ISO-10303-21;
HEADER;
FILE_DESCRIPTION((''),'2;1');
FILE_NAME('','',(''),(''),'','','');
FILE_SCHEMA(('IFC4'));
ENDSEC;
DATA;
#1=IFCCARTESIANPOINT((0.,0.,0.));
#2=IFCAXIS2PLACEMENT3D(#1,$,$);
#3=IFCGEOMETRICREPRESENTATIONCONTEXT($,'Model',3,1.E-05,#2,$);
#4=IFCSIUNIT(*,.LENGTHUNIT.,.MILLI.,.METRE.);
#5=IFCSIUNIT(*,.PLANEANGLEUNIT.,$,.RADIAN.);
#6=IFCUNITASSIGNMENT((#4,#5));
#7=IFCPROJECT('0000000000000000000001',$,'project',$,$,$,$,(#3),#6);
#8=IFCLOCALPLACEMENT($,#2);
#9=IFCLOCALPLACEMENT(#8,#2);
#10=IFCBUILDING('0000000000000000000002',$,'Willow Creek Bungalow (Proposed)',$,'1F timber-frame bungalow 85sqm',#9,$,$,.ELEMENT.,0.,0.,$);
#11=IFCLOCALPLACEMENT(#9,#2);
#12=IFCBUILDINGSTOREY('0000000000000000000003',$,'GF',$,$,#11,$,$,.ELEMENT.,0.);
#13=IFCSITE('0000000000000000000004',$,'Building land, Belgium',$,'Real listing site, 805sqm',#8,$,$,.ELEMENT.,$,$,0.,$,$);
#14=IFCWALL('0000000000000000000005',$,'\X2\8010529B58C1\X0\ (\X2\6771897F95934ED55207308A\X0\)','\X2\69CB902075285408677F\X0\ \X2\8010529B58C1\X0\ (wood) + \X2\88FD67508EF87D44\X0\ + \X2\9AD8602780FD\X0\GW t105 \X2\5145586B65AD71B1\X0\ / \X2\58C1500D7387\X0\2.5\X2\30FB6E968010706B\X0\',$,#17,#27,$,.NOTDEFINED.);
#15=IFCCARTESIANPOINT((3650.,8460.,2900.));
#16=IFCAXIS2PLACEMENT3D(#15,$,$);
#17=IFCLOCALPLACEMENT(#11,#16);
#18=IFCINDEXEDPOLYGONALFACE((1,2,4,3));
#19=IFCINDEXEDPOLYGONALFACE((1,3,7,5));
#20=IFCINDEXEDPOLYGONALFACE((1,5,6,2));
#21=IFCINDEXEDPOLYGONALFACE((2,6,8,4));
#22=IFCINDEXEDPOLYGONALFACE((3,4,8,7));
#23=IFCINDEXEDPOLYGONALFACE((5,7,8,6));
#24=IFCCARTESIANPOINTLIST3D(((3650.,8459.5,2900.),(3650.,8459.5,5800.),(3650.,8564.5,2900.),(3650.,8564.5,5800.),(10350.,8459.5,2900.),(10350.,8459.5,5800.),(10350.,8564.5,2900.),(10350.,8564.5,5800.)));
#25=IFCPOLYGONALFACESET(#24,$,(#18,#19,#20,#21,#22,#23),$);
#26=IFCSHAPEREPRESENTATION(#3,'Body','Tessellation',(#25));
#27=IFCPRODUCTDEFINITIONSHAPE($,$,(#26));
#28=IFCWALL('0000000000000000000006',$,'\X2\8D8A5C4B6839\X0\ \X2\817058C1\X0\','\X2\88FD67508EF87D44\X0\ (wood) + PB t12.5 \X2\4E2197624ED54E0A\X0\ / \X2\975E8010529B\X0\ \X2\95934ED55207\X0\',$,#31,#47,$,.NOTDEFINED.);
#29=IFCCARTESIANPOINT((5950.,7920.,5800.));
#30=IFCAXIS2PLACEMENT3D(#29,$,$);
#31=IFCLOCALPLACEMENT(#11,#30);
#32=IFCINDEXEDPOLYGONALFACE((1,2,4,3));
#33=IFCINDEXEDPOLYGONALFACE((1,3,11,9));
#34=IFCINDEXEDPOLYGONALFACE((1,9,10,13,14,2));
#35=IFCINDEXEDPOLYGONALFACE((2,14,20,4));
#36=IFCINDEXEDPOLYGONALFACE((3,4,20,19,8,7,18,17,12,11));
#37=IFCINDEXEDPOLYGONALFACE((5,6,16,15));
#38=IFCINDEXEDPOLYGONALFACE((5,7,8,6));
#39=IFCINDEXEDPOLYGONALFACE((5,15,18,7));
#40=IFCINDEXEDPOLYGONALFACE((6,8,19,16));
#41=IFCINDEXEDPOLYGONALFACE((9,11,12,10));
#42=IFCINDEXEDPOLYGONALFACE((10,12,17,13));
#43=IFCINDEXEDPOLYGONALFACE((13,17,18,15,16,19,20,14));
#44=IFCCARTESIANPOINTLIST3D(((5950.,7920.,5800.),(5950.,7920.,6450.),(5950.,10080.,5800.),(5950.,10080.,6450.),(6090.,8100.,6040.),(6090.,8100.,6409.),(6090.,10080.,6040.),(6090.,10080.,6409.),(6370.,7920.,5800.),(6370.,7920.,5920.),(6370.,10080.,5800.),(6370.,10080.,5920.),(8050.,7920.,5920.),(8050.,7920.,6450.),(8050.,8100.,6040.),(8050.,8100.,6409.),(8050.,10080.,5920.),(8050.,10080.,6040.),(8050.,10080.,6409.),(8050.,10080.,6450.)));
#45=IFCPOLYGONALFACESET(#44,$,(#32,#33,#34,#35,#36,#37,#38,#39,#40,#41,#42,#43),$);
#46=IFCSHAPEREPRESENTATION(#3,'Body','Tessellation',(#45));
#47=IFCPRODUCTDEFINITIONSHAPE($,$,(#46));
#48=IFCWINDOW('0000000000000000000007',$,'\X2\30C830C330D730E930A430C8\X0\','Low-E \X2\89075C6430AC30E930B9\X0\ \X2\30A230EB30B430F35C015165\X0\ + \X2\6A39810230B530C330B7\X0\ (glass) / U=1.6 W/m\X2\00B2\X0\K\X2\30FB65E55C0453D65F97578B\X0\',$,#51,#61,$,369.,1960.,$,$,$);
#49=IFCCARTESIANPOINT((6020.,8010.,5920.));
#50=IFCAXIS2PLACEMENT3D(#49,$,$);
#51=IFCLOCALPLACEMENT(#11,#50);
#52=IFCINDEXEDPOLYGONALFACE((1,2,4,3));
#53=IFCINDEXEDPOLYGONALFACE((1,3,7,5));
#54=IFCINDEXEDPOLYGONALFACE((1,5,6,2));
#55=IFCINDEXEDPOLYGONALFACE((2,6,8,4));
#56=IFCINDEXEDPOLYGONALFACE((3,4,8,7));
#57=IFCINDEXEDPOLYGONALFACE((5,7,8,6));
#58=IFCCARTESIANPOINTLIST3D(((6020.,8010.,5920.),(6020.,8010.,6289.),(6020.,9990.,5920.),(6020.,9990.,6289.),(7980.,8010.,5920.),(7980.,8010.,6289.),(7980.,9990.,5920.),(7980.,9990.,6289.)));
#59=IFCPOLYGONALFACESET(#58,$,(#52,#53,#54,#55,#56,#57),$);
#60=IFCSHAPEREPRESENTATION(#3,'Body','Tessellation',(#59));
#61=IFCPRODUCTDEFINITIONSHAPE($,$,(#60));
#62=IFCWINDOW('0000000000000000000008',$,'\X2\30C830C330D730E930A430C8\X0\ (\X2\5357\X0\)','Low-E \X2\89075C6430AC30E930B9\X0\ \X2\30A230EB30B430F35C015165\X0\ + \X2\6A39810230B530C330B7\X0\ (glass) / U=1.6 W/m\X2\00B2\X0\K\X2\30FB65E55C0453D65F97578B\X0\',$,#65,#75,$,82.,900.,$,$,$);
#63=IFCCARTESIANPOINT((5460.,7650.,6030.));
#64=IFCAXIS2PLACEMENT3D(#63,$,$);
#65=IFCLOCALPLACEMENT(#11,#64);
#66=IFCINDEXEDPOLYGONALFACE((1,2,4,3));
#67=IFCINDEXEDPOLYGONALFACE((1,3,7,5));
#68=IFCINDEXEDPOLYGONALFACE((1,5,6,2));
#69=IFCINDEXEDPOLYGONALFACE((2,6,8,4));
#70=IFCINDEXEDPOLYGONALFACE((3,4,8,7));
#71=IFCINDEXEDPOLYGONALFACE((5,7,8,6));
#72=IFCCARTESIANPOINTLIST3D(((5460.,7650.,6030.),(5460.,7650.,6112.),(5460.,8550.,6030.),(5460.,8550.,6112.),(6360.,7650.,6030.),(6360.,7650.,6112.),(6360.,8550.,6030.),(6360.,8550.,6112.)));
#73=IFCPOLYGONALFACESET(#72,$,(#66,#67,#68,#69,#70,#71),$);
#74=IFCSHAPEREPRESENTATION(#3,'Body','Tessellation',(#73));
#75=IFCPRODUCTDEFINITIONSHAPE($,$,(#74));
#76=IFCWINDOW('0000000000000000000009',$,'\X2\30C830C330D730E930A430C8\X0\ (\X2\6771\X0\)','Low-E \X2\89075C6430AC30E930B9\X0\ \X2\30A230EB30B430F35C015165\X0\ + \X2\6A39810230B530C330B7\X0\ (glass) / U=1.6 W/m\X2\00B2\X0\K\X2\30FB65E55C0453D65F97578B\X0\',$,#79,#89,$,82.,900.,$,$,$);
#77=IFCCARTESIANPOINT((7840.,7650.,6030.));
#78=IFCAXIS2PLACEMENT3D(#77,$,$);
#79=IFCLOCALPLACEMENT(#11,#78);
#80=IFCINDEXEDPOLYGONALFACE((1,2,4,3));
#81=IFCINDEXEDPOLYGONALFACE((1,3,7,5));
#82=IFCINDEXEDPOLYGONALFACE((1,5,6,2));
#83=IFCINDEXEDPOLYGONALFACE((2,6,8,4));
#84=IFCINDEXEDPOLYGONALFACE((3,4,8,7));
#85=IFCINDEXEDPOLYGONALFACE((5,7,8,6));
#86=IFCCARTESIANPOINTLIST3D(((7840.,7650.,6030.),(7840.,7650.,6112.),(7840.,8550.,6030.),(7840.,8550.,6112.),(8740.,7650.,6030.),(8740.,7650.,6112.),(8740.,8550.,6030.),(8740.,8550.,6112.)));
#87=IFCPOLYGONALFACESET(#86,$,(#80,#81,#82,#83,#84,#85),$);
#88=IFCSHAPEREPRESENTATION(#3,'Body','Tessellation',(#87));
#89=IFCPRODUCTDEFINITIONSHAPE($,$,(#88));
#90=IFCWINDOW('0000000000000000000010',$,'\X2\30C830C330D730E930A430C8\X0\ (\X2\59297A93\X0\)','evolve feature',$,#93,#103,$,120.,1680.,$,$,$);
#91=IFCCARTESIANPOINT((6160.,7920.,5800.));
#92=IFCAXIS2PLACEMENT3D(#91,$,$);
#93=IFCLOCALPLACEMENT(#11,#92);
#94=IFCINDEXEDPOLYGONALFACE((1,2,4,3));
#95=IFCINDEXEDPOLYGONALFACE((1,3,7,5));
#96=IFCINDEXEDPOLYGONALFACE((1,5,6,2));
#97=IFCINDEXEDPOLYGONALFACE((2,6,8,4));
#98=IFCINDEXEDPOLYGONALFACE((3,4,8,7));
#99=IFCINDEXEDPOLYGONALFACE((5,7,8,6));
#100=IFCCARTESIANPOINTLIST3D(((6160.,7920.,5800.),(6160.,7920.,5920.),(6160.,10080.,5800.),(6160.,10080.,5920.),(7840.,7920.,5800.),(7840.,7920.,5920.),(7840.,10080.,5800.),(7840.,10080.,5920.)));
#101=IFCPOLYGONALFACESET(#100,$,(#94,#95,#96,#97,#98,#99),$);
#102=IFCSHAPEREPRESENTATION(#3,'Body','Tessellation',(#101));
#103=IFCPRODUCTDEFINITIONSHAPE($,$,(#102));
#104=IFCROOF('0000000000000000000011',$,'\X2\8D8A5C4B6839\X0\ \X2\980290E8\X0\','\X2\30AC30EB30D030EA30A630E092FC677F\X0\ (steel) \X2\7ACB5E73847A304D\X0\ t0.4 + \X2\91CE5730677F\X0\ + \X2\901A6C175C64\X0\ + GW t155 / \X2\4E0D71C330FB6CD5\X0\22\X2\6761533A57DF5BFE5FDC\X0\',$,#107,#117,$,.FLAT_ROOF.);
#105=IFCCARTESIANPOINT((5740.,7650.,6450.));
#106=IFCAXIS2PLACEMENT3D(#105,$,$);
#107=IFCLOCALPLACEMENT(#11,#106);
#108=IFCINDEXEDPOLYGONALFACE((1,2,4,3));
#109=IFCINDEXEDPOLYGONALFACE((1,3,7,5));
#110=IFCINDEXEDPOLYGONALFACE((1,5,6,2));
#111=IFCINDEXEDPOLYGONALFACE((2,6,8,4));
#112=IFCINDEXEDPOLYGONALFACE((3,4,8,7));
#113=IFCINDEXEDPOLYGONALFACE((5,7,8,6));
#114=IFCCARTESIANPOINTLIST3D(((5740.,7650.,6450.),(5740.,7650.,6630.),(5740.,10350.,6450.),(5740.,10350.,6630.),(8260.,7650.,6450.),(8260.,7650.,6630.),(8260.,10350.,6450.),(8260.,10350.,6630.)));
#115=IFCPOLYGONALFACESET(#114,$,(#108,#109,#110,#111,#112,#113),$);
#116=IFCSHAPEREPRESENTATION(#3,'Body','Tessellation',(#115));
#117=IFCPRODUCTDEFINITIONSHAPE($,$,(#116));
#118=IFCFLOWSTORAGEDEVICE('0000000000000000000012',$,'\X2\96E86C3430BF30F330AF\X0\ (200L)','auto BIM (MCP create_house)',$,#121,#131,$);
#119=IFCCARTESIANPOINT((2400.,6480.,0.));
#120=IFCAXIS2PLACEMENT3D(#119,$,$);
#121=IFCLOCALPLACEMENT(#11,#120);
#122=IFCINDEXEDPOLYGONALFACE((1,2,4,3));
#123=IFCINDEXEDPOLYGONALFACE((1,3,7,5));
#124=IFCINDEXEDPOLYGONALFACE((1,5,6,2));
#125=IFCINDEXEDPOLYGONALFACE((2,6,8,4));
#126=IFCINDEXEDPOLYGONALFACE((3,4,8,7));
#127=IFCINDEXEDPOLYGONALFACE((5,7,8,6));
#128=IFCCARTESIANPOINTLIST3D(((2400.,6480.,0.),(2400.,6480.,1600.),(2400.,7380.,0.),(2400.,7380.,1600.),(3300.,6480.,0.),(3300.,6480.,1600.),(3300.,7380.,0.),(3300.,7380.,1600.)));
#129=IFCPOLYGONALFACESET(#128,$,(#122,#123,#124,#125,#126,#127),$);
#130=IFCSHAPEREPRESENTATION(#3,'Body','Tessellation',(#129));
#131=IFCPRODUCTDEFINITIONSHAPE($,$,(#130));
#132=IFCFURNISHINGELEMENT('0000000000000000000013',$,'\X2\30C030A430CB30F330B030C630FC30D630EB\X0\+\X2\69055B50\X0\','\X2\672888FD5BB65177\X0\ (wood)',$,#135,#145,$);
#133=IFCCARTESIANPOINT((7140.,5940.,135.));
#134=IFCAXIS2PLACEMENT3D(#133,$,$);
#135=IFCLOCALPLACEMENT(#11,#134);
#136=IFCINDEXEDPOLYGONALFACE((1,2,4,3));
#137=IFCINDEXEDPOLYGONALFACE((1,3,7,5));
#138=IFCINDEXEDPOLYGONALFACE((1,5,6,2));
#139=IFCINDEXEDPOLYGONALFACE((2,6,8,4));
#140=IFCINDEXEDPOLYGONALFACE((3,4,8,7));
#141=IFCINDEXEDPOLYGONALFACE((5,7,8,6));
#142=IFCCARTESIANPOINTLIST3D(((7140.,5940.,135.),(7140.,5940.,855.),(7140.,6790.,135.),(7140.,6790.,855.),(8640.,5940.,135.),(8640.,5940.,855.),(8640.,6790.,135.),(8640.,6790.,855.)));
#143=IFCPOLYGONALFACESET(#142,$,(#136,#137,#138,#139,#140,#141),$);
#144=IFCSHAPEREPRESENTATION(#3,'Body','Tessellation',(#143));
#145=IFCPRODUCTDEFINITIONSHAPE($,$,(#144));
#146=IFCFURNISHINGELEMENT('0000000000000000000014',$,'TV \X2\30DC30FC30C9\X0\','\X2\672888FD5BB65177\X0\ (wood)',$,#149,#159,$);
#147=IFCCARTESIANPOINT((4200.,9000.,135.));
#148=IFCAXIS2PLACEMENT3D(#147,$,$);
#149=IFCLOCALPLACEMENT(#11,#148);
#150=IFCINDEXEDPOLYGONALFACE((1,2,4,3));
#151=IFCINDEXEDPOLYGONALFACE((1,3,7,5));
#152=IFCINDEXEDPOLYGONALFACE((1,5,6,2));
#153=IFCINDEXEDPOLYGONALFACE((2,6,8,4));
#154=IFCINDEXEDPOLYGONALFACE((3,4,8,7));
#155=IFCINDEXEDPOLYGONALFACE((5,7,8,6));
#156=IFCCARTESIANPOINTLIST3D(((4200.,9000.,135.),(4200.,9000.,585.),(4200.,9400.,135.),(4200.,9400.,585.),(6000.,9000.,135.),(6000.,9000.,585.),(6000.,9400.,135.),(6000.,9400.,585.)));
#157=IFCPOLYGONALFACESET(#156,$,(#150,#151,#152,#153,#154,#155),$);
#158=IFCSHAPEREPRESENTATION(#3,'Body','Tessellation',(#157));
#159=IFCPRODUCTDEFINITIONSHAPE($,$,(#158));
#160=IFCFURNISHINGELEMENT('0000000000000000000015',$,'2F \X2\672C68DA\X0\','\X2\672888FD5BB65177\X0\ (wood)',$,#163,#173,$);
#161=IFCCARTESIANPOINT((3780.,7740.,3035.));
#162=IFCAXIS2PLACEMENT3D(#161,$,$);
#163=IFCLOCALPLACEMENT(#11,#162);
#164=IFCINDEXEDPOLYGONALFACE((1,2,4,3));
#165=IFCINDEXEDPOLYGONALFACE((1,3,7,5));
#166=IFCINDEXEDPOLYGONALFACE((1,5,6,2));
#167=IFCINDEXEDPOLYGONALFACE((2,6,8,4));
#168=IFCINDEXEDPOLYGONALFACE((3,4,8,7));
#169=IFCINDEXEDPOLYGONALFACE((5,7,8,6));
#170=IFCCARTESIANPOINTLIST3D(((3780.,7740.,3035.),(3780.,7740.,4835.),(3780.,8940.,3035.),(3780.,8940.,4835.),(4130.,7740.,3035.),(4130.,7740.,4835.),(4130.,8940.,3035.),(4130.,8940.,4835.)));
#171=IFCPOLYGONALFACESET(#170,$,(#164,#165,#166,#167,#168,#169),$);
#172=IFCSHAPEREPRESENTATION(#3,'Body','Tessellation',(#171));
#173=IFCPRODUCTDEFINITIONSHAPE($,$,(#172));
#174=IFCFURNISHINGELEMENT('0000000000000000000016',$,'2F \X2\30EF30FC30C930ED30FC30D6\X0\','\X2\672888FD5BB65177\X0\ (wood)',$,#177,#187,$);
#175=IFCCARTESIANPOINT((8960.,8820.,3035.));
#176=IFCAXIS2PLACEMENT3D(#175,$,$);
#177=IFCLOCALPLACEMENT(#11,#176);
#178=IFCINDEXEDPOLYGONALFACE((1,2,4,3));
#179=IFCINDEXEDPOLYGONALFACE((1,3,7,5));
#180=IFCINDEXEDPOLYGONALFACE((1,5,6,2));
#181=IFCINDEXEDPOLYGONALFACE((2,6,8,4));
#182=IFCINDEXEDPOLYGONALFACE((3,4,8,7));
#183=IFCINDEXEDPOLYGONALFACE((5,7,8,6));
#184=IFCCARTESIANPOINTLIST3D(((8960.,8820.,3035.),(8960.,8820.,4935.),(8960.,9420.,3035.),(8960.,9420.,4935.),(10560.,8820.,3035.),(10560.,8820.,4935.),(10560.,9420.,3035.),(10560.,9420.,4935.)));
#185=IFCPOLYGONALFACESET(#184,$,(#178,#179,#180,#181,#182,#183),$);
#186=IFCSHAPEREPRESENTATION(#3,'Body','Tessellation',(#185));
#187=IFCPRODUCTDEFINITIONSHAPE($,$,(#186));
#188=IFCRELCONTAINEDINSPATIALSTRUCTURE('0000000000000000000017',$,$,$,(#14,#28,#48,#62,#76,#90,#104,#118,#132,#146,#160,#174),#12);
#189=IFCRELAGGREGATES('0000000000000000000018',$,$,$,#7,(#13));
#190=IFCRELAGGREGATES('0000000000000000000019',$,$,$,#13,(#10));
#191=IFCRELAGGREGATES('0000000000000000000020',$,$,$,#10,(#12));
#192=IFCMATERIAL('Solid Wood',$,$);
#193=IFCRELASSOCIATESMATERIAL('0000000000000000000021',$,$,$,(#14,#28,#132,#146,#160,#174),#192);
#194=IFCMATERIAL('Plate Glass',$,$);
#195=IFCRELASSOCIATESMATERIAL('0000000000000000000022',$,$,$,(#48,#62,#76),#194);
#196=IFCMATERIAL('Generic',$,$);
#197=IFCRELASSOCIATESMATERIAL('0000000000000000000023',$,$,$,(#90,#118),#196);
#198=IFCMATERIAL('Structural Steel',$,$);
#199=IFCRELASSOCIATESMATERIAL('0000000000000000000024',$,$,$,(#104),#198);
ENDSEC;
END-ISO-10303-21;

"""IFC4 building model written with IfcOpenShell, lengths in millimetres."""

from ifc_helpers import new_model, si_unit, frame, frame_2d, origin, place, context, project, spatial, rectangle, extrude, material, element, fill, save


model = new_model("IFC4")

# Units and contexts
model_context = context("Model", 3, precision=1e-05, world=origin())
ifc_project = project(units=[si_unit("LENGTHUNIT", "METRE", prefix="MILLI"), si_unit("PLANEANGLEUNIT", "RADIAN")], contexts=[model_context])

# Site, building, storey
site_placement = place(None, origin())
site = spatial("IfcSite", under=ifc_project, at=site_placement, Name="Building land, Belgium", ObjectType="Real listing site, 805sqm", CompositionType="ELEMENT", RefElevation=0.0)
building_placement = place(site_placement, origin())
building = spatial("IfcBuilding", under=site, at=building_placement, Name="Willow Creek Bungalow (Proposed)", ObjectType="1F timber-frame bungalow 85sqm", CompositionType="ELEMENT", ElevationOfRefHeight=0.0, ElevationOfTerrain=0.0)
storey_placement = place(building_placement, origin())
storey = spatial("IfcBuildingStorey", under=building, at=storey_placement, Name="GF", CompositionType="ELEMENT", Elevation=0.0)

# Wall
ifc_material_1 = material(Name="Solid Wood")
wall_1_placement = place(storey_placement, frame((3650.0, 8460.0, 2900.0)))
element("IfcWall", 1, at=wall_1_placement, inside=storey, material=ifc_material_1, Name="耐力壁 (東西間仕切り)", Description="構造用合板 耐力壁 (wood) + 製材軸組 + 高性能GW t105 充填断熱 / 壁倍率2.5・準耐火", PredefinedType="NOTDEFINED", context=model_context, shape_type="SweptSolid", body=[
    extrude(rectangle(XDim=6700.0, YDim=105.0, at=frame_2d((3350.0, 52.0))), frame((3650.0, 8460.0, 2900.0)), (0.0, 0.0, 1.0), 2900.0),
])

# Wall, openings, windows
wall_2_placement = place(storey_placement, frame((5950.0, 7920.0, 5800.0)))
wall_2 = element("IfcWall", 2, at=wall_2_placement, inside=storey, material=ifc_material_1, Name="越屋根 腰壁", Description="製材軸組 (wood) + PB t12.5 両面仕上 / 非耐力 間仕切", PredefinedType="NOTDEFINED", context=model_context, shape_type="SweptSolid", body=[
    extrude(rectangle(XDim=2100.0, YDim=2160.0, at=frame_2d((1050.0, 1080.0))), frame((5950.0, 7920.0, 5800.0)), (0.0, 0.0, 1.0), 650.0),
])
opening_1_placement = place(storey_placement, frame((6020.0, 8010.0, 5920.0)))
opening_1 = element("IfcOpeningElement", 3, at=opening_1_placement, cuts=wall_2, PredefinedType="NOTDEFINED", context=model_context, shape_type="SweptSolid", body=[
    extrude(rectangle(XDim=1960.0, YDim=1980.0, at=frame_2d((980.0, 990.0))), frame((6020.0, 8010.0, 5920.0)), (0.0, 0.0, 1.0), 369.0),
])
opening_2_placement = place(storey_placement, frame((5460.0, 7650.0, 6030.0)))
opening_2 = element("IfcOpeningElement", 4, at=opening_2_placement, cuts=wall_2, PredefinedType="NOTDEFINED", context=model_context, shape_type="SweptSolid", body=[
    extrude(rectangle(XDim=900.0, YDim=900.0, at=frame_2d((450.0, 450.0))), frame((5460.0, 7650.0, 6030.0)), (0.0, 0.0, 1.0), 82.0),
])
opening_3_placement = place(storey_placement, frame((7840.0, 7650.0, 6030.0)))
opening_3 = element("IfcOpeningElement", 5, at=opening_3_placement, cuts=wall_2, PredefinedType="NOTDEFINED", context=model_context, shape_type="SweptSolid", body=[
    extrude(rectangle(XDim=900.0, YDim=900.0, at=frame_2d((450.0, 450.0))), frame((7840.0, 7650.0, 6030.0)), (0.0, 0.0, 1.0), 82.0),
])
opening_4_placement = place(storey_placement, frame((6160.0, 7920.0, 5800.0)))
opening_4 = element("IfcOpeningElement", 6, at=opening_4_placement, cuts=wall_2, PredefinedType="NOTDEFINED", context=model_context, shape_type="SweptSolid", body=[
    extrude(rectangle(XDim=1680.0, YDim=2160.0, at=frame_2d((840.0, 1080.0))), frame((6160.0, 7920.0, 5800.0)), (0.0, 0.0, 1.0), 120.0),
])
ifc_material_2 = material(Name="Plate Glass")
window_1_placement = place(storey_placement, frame((6020.0, 8010.0, 5920.0)))
window_1 = element("IfcWindow", 7, at=window_1_placement, inside=storey, material=ifc_material_2, Name="トップライト", Description="Low-E 複層ガラス アルゴン封入 + 樹脂サッシ (glass) / U=1.6 W/m²K・日射取得型", OverallHeight=369.0, OverallWidth=1960.0, context=model_context, shape_type="SweptSolid", body=[
    extrude(rectangle(XDim=1960.0, YDim=1980.0, at=frame_2d((980.0, 990.0))), frame((6020.0, 8010.0, 5920.0)), (0.0, 0.0, 1.0), 369.0),
])
fill(opening_1, window_1)
window_2_placement = place(storey_placement, frame((5460.0, 7650.0, 6030.0)))
window_2 = element("IfcWindow", 8, at=window_2_placement, inside=storey, material=ifc_material_2, Name="トップライト (南)", Description="Low-E 複層ガラス アルゴン封入 + 樹脂サッシ (glass) / U=1.6 W/m²K・日射取得型", OverallHeight=82.0, OverallWidth=900.0, context=model_context, shape_type="SweptSolid", body=[
    extrude(rectangle(XDim=900.0, YDim=900.0, at=frame_2d((450.0, 450.0))), frame((5460.0, 7650.0, 6030.0)), (0.0, 0.0, 1.0), 82.0),
])
fill(opening_2, window_2)
window_3_placement = place(storey_placement, frame((7840.0, 7650.0, 6030.0)))
window_3 = element("IfcWindow", 9, at=window_3_placement, inside=storey, material=ifc_material_2, Name="トップライト (東)", Description="Low-E 複層ガラス アルゴン封入 + 樹脂サッシ (glass) / U=1.6 W/m²K・日射取得型", OverallHeight=82.0, OverallWidth=900.0, context=model_context, shape_type="SweptSolid", body=[
    extrude(rectangle(XDim=900.0, YDim=900.0, at=frame_2d((450.0, 450.0))), frame((7840.0, 7650.0, 6030.0)), (0.0, 0.0, 1.0), 82.0),
])
fill(opening_3, window_3)
ifc_material_3 = material(Name="Generic")
window_4_placement = place(storey_placement, frame((6160.0, 7920.0, 5800.0)))
window_4 = element("IfcWindow", 10, at=window_4_placement, inside=storey, material=ifc_material_3, Name="トップライト (天窓)", Description="evolve feature", OverallHeight=120.0, OverallWidth=1680.0, context=model_context, shape_type="SweptSolid", body=[
    extrude(rectangle(XDim=1680.0, YDim=2160.0, at=frame_2d((840.0, 1080.0))), frame((6160.0, 7920.0, 5800.0)), (0.0, 0.0, 1.0), 120.0),
])
fill(opening_4, window_4)

# Roof
ifc_material_4 = material(Name="Structural Steel")
roof_placement = place(storey_placement, frame((5740.0, 7650.0, 6450.0)))
element("IfcRoof", 11, at=roof_placement, inside=storey, material=ifc_material_4, Name="越屋根 頂部", Description="ガルバリウム鋼板 (steel) 立平葺き t0.4 + 野地板 + 通気層 + GW t155 / 不燃・法22条区域対応", PredefinedType="FLAT_ROOF", context=model_context, shape_type="SweptSolid", body=[
    extrude(rectangle(XDim=2520.0, YDim=2700.0, at=frame_2d((1260.0, 1350.0))), frame((5740.0, 7650.0, 6450.0)), (0.0, 0.0, 1.0), 180.0),
])

# Flow storage device
flow_storage_device_placement = place(storey_placement, frame((2400.0, 6480.0, 0.0)))
element("IfcFlowStorageDevice", 12, at=flow_storage_device_placement, inside=storey, material=ifc_material_3, Name="雨水タンク (200L)", Description="auto BIM (MCP create_house)", context=model_context, shape_type="SweptSolid", body=[
    extrude(rectangle(XDim=900.0, YDim=900.0, at=frame_2d((450.0, 450.0))), frame((2400.0, 6480.0, 0.0)), (0.0, 0.0, 1.0), 1600.0),
])

# Furnishing elements
furnishing_1_placement = place(storey_placement, frame((7140.0, 5940.0, 135.0)))
element("IfcFurnishingElement", 13, at=furnishing_1_placement, inside=storey, material=ifc_material_1, Name="ダイニングテーブル+椅子", Description="木製家具 (wood)", context=model_context, shape_type="SweptSolid", body=[
    extrude(rectangle(XDim=1500.0, YDim=850.0, at=frame_2d((750.0, 425.0))), frame((7140.0, 5940.0, 135.0)), (0.0, 0.0, 1.0), 720.0),
])
furnishing_2_placement = place(storey_placement, frame((4200.0, 9000.0, 135.0)))
element("IfcFurnishingElement", 14, at=furnishing_2_placement, inside=storey, material=ifc_material_1, Name="TV ボード", Description="木製家具 (wood)", context=model_context, shape_type="SweptSolid", body=[
    extrude(rectangle(XDim=1800.0, YDim=400.0, at=frame_2d((900.0, 200.0))), frame((4200.0, 9000.0, 135.0)), (0.0, 0.0, 1.0), 450.0),
])
furnishing_3_placement = place(storey_placement, frame((3780.0, 7740.0, 3035.0)))
element("IfcFurnishingElement", 15, at=furnishing_3_placement, inside=storey, material=ifc_material_1, Name="2F 本棚", Description="木製家具 (wood)", context=model_context, shape_type="SweptSolid", body=[
    extrude(rectangle(XDim=350.0, YDim=1200.0, at=frame_2d((175.0, 600.0))), frame((3780.0, 7740.0, 3035.0)), (0.0, 0.0, 1.0), 1800.0),
])
furnishing_4_placement = place(storey_placement, frame((8960.0, 8820.0, 3035.0)))
element("IfcFurnishingElement", 16, at=furnishing_4_placement, inside=storey, material=ifc_material_1, Name="2F ワードローブ", Description="木製家具 (wood)", context=model_context, shape_type="SweptSolid", body=[
    extrude(rectangle(XDim=1600.0, YDim=600.0, at=frame_2d((800.0, 300.0))), frame((8960.0, 8820.0, 3035.0)), (0.0, 0.0, 1.0), 1900.0),
])

save(model, "model.ifc")
